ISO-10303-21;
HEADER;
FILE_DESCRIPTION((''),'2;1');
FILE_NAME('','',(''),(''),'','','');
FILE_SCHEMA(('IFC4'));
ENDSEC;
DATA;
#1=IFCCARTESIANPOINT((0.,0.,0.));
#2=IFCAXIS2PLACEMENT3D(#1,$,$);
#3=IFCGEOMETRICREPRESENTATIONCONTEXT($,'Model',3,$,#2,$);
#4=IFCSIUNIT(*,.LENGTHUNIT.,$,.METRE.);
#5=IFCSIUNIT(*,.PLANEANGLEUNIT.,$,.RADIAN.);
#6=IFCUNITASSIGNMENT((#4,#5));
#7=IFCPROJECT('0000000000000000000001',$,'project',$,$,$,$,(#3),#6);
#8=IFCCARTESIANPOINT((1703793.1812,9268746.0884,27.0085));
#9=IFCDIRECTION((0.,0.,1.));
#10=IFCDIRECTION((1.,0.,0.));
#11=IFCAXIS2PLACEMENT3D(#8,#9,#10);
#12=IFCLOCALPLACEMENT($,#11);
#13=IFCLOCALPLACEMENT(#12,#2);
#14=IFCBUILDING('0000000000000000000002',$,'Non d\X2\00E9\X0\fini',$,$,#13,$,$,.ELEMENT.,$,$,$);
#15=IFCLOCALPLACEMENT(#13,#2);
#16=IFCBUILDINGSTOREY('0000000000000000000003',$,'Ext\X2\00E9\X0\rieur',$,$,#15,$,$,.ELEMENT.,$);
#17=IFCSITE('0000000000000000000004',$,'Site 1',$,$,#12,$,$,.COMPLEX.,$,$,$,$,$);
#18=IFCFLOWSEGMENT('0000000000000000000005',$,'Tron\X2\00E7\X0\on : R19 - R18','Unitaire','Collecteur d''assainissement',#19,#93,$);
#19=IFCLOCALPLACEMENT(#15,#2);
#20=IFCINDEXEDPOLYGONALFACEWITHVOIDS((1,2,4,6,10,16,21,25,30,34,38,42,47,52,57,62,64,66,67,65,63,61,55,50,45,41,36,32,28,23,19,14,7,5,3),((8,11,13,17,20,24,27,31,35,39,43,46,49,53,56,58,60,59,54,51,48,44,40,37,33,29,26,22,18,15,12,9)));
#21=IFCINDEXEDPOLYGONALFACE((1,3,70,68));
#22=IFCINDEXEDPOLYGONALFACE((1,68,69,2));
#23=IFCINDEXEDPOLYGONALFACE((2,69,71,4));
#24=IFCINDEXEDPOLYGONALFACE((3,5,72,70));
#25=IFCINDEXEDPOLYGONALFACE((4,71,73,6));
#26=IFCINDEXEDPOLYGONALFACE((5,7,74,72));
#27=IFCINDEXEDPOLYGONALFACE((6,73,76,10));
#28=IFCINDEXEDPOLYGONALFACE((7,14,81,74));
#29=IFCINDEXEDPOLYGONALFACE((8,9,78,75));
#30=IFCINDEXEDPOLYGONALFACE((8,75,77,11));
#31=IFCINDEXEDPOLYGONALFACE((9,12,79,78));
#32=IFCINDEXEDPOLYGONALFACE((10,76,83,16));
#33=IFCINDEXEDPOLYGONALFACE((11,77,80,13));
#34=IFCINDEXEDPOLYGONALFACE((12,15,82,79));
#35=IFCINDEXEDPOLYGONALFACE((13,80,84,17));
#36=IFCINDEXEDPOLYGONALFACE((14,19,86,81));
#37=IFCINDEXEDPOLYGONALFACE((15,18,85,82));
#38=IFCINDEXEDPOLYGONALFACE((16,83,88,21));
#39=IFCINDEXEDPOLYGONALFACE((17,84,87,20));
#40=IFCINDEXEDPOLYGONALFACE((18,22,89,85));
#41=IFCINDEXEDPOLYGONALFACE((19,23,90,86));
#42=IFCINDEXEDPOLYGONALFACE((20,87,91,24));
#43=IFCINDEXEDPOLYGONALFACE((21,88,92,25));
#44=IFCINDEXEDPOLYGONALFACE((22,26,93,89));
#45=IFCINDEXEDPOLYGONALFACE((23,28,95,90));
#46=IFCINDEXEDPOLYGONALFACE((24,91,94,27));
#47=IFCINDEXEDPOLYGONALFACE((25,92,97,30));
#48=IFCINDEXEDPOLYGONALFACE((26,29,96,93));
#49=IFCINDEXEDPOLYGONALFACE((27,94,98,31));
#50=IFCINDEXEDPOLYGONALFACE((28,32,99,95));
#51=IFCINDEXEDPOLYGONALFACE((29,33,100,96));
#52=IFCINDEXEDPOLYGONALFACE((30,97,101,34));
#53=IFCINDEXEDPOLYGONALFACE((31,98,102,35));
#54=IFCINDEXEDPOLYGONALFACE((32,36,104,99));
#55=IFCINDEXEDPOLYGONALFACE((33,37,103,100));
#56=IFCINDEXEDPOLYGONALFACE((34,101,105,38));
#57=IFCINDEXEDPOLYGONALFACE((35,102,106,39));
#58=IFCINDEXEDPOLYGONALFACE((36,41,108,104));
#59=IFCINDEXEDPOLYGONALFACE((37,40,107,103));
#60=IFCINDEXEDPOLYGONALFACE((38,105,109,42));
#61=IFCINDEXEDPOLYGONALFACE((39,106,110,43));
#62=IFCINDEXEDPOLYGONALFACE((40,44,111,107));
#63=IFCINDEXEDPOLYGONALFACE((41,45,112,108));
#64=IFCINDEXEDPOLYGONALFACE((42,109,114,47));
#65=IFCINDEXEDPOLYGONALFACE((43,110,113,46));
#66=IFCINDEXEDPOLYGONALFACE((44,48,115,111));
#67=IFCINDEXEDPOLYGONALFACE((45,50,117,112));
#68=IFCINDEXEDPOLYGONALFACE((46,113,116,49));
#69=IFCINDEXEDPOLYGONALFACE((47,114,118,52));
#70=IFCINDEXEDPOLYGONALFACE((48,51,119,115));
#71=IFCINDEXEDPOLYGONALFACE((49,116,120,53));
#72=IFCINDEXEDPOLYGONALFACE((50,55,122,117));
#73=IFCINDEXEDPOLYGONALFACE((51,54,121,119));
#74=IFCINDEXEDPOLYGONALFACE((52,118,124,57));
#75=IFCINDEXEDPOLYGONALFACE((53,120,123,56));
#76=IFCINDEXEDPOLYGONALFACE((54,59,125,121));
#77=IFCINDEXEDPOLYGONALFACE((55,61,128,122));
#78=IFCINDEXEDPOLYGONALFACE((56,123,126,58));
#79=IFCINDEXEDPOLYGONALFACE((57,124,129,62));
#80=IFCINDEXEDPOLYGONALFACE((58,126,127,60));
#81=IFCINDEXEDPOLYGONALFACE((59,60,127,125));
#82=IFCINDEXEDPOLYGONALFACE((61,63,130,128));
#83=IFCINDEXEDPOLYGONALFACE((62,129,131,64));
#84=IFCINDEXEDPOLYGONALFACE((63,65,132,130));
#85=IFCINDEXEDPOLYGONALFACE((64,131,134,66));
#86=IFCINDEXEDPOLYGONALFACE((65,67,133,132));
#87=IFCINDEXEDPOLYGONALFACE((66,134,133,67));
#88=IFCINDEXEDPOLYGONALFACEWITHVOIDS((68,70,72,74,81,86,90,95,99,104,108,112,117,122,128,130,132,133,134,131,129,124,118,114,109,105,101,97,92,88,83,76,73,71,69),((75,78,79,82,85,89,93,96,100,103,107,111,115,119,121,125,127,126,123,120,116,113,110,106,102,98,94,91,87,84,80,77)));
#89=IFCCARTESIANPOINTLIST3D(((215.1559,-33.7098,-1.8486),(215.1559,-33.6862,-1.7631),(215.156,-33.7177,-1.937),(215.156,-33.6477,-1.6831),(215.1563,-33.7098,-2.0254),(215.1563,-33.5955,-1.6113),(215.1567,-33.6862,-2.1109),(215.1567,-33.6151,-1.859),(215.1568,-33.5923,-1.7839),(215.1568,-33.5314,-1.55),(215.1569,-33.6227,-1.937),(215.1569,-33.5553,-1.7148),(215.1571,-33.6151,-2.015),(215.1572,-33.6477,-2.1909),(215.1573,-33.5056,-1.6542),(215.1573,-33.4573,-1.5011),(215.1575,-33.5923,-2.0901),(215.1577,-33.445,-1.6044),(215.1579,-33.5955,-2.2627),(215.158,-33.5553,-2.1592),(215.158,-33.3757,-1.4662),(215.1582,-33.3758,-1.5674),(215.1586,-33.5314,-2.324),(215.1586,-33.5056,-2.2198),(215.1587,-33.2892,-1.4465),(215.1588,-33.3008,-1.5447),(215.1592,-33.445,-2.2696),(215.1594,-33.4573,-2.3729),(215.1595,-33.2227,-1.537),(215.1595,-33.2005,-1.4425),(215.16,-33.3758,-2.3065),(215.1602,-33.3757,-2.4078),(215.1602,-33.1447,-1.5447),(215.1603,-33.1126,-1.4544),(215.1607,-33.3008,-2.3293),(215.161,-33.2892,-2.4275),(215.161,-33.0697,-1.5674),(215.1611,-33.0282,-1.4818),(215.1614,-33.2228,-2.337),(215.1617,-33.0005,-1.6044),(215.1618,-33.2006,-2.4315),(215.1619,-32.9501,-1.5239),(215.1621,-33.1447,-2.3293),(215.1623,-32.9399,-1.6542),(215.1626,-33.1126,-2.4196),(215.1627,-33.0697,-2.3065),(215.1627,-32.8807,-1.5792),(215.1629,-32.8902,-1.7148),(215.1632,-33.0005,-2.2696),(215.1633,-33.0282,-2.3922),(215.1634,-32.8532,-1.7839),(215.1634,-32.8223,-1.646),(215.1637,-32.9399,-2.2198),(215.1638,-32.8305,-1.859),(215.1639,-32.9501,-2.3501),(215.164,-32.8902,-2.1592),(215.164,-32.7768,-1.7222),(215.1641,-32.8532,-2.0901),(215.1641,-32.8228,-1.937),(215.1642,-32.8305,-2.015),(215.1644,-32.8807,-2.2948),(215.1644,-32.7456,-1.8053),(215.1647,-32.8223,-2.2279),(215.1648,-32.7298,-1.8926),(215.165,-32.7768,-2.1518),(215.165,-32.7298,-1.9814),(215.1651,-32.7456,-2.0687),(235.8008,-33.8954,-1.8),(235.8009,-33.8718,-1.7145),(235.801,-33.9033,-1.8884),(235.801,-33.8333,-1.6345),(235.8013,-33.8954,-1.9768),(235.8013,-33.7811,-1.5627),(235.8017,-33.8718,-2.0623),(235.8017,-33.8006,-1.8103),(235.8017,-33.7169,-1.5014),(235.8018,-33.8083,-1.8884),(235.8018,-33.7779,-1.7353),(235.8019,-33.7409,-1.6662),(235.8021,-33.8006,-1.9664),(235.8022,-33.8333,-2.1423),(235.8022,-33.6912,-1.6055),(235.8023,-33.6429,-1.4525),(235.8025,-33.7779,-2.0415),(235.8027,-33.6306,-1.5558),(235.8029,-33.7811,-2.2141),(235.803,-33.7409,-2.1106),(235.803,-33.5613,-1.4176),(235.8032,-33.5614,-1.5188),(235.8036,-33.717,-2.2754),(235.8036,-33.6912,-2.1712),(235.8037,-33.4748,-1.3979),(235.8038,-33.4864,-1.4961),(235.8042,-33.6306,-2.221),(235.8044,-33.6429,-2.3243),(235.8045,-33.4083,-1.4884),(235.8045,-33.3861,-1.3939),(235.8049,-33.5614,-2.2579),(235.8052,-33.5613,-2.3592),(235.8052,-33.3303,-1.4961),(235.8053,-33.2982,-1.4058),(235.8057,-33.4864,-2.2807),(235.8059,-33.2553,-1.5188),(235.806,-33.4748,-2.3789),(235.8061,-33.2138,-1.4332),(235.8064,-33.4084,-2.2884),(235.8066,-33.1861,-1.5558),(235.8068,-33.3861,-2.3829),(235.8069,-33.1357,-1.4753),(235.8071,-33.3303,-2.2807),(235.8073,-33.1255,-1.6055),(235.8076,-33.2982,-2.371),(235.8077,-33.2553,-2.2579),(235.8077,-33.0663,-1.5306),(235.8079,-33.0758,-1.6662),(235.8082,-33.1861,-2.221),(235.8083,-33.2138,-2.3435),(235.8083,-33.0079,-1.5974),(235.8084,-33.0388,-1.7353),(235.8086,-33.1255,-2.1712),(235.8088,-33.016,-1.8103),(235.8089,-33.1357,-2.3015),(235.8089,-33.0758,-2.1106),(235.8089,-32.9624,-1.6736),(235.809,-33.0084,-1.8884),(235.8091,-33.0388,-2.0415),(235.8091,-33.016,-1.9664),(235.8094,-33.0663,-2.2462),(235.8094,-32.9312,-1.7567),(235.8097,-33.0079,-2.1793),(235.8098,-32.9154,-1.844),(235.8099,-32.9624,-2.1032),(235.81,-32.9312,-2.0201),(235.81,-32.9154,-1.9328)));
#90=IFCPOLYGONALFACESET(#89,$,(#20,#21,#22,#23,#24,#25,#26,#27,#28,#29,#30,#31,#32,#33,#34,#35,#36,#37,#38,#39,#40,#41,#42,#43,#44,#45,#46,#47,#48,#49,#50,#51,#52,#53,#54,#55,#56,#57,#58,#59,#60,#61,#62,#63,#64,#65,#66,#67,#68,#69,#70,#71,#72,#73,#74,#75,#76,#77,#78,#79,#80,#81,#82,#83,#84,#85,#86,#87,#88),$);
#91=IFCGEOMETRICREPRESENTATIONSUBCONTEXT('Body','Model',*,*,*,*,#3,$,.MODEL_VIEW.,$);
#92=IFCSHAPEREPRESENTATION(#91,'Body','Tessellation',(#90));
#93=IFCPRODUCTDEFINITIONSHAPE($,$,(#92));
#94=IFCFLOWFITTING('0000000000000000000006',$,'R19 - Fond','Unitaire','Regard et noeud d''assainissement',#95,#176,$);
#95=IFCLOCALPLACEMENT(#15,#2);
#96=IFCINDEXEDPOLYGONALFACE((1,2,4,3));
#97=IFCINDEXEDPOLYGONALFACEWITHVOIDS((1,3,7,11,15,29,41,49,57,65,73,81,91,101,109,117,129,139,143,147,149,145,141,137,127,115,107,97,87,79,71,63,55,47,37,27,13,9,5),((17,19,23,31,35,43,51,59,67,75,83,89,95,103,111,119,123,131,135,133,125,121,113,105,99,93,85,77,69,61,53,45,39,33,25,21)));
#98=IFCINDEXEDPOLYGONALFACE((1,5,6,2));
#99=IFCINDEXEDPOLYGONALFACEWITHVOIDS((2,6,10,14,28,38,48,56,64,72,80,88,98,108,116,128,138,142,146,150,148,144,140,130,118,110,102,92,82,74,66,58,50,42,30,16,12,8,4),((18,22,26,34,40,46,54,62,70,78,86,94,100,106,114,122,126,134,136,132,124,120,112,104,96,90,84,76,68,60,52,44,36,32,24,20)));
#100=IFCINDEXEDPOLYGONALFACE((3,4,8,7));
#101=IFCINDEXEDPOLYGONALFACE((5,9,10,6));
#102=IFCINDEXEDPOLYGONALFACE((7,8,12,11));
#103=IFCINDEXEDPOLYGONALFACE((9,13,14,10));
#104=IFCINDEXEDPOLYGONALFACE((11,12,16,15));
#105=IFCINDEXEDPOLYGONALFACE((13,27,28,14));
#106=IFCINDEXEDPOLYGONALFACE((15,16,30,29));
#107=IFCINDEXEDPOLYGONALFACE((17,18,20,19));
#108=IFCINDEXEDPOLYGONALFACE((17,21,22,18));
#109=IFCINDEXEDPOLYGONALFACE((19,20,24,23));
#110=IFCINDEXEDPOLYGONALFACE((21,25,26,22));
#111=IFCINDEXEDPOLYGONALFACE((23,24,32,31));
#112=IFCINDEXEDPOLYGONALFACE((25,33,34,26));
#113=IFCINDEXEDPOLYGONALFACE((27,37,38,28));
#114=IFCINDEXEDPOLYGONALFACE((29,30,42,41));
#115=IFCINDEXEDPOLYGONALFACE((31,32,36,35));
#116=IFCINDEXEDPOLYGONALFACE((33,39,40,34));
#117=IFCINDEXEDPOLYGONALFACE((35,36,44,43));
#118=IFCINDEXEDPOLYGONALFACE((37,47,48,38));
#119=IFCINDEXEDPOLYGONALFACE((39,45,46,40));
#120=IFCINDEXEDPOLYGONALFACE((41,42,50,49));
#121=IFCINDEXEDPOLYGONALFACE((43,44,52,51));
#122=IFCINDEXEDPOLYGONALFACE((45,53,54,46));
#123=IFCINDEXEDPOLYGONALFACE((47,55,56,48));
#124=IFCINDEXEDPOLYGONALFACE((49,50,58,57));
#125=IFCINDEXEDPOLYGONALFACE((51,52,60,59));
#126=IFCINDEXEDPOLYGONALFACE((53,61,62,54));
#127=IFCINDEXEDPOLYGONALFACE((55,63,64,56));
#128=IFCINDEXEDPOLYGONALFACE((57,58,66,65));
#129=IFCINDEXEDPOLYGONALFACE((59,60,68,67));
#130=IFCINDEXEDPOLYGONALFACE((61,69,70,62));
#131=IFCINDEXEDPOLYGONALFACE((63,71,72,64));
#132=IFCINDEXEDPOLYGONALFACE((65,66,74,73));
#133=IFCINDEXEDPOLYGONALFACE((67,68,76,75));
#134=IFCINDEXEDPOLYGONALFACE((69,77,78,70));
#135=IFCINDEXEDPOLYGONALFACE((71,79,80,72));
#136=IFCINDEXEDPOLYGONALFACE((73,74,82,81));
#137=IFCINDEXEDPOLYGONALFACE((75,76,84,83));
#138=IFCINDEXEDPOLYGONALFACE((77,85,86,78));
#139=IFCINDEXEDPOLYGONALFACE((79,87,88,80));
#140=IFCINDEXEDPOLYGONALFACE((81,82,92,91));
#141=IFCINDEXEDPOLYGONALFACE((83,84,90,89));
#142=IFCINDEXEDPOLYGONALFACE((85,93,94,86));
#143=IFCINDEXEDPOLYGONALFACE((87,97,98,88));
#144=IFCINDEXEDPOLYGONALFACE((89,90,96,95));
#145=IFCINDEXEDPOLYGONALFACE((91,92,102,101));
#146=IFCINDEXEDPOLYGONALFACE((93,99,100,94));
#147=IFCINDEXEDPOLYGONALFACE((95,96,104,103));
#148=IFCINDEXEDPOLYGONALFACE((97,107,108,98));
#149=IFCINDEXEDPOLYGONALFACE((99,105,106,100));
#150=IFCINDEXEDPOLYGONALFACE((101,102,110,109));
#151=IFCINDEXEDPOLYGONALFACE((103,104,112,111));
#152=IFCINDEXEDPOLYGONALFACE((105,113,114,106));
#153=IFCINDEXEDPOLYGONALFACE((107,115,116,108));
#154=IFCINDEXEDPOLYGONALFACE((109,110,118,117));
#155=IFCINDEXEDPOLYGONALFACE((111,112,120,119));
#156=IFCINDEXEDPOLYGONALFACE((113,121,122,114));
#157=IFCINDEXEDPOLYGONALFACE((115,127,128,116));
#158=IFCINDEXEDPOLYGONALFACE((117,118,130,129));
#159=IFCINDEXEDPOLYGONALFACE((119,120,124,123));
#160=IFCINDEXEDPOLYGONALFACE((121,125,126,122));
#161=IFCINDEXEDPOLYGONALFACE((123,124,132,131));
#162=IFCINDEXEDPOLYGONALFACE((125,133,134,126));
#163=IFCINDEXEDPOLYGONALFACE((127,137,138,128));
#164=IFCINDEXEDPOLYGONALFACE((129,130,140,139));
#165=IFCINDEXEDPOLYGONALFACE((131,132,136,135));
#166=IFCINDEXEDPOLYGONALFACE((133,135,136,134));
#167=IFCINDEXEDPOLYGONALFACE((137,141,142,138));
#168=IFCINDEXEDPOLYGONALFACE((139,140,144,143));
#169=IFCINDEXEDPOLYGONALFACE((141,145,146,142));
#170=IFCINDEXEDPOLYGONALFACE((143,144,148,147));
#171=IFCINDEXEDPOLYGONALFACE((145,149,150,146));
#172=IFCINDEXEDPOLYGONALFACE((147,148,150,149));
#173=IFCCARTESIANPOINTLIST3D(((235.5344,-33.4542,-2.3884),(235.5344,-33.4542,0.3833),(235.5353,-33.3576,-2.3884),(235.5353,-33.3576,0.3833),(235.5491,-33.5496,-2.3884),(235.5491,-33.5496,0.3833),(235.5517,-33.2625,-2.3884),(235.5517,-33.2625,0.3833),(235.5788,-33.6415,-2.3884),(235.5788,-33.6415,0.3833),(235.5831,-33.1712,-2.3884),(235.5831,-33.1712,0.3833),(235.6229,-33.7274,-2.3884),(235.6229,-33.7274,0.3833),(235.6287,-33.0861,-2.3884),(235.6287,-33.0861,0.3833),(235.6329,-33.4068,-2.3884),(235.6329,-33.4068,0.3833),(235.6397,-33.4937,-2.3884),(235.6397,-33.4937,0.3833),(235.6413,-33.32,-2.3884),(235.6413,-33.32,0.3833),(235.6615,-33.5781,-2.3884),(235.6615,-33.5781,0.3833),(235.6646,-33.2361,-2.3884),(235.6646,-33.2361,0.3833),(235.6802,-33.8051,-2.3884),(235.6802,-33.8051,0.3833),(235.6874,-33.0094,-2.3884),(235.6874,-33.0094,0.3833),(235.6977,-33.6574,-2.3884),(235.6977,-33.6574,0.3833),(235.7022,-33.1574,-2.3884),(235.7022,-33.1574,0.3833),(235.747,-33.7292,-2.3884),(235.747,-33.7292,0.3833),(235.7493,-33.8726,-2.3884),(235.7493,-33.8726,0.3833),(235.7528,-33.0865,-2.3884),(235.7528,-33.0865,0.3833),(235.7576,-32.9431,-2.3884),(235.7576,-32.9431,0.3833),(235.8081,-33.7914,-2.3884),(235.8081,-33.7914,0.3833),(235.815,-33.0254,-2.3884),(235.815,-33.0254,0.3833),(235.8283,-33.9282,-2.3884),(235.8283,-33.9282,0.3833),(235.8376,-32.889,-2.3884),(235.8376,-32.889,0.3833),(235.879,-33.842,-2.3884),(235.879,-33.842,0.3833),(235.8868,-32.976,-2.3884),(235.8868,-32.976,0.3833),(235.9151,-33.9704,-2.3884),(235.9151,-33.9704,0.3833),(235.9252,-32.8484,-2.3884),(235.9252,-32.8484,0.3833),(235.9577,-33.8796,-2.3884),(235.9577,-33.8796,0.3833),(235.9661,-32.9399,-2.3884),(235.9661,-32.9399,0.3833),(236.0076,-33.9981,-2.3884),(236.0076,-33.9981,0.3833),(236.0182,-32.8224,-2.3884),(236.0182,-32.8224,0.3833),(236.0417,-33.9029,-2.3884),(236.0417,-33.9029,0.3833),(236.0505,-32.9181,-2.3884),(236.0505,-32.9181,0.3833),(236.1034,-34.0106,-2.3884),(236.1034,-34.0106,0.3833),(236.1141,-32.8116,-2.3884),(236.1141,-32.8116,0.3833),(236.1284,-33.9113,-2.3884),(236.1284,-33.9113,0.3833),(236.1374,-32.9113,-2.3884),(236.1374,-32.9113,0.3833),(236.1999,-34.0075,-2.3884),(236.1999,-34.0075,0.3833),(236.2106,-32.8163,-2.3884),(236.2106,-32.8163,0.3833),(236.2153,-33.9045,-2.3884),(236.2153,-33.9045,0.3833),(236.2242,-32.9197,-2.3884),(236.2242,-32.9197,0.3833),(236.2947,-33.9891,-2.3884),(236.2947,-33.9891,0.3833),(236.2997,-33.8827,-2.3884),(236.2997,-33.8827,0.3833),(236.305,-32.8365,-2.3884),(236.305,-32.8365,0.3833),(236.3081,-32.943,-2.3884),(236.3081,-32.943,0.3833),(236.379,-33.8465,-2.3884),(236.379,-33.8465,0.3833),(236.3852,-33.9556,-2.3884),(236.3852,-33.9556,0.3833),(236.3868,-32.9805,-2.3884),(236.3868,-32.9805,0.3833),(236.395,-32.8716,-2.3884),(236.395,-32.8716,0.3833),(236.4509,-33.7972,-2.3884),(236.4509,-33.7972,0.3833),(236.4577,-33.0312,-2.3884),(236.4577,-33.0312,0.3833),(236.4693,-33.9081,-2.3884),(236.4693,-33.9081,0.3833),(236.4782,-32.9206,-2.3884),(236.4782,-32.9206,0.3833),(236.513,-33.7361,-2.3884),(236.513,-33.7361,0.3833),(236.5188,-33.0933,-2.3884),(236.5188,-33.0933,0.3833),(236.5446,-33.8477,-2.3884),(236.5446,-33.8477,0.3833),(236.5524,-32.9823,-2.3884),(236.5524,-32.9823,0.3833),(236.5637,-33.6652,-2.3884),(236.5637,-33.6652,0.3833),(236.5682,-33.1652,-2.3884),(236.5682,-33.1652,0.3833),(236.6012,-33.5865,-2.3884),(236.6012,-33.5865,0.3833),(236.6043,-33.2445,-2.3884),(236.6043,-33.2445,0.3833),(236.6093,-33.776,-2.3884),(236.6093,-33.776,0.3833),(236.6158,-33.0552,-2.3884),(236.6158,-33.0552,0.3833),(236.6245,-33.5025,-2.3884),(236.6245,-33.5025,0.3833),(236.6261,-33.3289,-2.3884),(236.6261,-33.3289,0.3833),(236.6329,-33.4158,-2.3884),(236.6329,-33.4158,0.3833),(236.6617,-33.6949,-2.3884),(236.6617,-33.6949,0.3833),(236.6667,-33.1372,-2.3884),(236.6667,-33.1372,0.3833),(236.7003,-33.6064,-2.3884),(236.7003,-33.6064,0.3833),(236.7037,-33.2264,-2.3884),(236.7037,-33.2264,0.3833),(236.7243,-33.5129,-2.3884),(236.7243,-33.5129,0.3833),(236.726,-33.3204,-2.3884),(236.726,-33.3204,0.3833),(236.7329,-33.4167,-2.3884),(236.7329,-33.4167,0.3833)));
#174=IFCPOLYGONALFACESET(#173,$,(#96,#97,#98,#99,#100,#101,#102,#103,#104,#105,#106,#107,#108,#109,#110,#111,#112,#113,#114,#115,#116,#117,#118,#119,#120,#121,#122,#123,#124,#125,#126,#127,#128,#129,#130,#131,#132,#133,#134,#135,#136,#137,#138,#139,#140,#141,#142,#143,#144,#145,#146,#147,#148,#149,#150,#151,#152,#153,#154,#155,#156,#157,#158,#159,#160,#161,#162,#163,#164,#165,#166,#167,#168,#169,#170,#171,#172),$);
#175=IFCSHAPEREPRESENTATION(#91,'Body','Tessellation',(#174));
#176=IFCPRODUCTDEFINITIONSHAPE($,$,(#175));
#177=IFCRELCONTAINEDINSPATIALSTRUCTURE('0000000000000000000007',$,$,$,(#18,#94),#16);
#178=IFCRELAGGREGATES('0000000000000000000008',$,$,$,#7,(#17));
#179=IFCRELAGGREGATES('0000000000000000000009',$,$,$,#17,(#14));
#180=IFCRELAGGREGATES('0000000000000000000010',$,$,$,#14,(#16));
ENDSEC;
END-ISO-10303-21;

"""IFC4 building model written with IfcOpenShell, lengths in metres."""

from ifc_helpers import new_model, si_unit, frame, origin, origin_2d, place, context, subcontext, project, spatial, hollow_circle, extrude, element, save


model = new_model("IFC4")

# Units and contexts
model_context = context("Model", 3, world=origin())
body_context = subcontext(model_context, "Body", "Model", "MODEL_VIEW")
ifc_project = project(units=[si_unit("LENGTHUNIT", "METRE"), si_unit("PLANEANGLEUNIT", "RADIAN")], contexts=[model_context])

# Site, building, storey
site_placement = place(None, frame((1703793.1812, 9268746.0884, 27.0085), z_axis=(0.0, 0.0, 1.0), x_axis=(1.0, 0.0, 0.0)))
site = spatial("IfcSite", under=ifc_project, at=site_placement, Name="Site 1", CompositionType="COMPLEX")
building_placement = place(site_placement, origin())
building = spatial("IfcBuilding", under=site, at=building_placement, Name="Non défini", CompositionType="ELEMENT")
storey_placement = place(building_placement, origin())
storey = spatial("IfcBuildingStorey", under=building, at=storey_placement, Name="Extérieur", CompositionType="ELEMENT")

# Flow segment
flow_segment_1_placement = place(storey_placement, origin())
element("IfcFlowSegment", 1, at=flow_segment_1_placement, inside=storey, Name="Tronçon : R19 - R18", Description="Unitaire", ObjectType="Collecteur d'assainissement", context=body_context, shape_type="SweptSolid", body=[
    extrude(hollow_circle(Radius=0.495, WallThickness=0.095, at=origin_2d()), frame((235.8054, -33.4083, -1.8884), z_axis=(-1.0, 0.00899, -0.002354), x_axis=(-0.00899, -1.0, 0.0)), (0.0, 0.0, 1.0), 20.6459),
])

# Flow fitting
flow_fitting_1_placement = place(storey_placement, origin())
element("IfcFlowFitting", 2, at=flow_fitting_1_placement, inside=storey, Name="R19 - Fond", Description="Unitaire", ObjectType="Regard et noeud d'assainissement", context=body_context, shape_type="SweptSolid", body=[
    extrude(hollow_circle(Radius=0.6, WallThickness=0.1, at=origin_2d()), frame((236.1329, -33.4113, -2.3884), z_axis=(0.0, 0.0, 1.0), x_axis=(1.0, -0.00899, 0.0)), (0.0, 0.0, 1.0), 2.7717),
])

save(model, "model.ifc")
